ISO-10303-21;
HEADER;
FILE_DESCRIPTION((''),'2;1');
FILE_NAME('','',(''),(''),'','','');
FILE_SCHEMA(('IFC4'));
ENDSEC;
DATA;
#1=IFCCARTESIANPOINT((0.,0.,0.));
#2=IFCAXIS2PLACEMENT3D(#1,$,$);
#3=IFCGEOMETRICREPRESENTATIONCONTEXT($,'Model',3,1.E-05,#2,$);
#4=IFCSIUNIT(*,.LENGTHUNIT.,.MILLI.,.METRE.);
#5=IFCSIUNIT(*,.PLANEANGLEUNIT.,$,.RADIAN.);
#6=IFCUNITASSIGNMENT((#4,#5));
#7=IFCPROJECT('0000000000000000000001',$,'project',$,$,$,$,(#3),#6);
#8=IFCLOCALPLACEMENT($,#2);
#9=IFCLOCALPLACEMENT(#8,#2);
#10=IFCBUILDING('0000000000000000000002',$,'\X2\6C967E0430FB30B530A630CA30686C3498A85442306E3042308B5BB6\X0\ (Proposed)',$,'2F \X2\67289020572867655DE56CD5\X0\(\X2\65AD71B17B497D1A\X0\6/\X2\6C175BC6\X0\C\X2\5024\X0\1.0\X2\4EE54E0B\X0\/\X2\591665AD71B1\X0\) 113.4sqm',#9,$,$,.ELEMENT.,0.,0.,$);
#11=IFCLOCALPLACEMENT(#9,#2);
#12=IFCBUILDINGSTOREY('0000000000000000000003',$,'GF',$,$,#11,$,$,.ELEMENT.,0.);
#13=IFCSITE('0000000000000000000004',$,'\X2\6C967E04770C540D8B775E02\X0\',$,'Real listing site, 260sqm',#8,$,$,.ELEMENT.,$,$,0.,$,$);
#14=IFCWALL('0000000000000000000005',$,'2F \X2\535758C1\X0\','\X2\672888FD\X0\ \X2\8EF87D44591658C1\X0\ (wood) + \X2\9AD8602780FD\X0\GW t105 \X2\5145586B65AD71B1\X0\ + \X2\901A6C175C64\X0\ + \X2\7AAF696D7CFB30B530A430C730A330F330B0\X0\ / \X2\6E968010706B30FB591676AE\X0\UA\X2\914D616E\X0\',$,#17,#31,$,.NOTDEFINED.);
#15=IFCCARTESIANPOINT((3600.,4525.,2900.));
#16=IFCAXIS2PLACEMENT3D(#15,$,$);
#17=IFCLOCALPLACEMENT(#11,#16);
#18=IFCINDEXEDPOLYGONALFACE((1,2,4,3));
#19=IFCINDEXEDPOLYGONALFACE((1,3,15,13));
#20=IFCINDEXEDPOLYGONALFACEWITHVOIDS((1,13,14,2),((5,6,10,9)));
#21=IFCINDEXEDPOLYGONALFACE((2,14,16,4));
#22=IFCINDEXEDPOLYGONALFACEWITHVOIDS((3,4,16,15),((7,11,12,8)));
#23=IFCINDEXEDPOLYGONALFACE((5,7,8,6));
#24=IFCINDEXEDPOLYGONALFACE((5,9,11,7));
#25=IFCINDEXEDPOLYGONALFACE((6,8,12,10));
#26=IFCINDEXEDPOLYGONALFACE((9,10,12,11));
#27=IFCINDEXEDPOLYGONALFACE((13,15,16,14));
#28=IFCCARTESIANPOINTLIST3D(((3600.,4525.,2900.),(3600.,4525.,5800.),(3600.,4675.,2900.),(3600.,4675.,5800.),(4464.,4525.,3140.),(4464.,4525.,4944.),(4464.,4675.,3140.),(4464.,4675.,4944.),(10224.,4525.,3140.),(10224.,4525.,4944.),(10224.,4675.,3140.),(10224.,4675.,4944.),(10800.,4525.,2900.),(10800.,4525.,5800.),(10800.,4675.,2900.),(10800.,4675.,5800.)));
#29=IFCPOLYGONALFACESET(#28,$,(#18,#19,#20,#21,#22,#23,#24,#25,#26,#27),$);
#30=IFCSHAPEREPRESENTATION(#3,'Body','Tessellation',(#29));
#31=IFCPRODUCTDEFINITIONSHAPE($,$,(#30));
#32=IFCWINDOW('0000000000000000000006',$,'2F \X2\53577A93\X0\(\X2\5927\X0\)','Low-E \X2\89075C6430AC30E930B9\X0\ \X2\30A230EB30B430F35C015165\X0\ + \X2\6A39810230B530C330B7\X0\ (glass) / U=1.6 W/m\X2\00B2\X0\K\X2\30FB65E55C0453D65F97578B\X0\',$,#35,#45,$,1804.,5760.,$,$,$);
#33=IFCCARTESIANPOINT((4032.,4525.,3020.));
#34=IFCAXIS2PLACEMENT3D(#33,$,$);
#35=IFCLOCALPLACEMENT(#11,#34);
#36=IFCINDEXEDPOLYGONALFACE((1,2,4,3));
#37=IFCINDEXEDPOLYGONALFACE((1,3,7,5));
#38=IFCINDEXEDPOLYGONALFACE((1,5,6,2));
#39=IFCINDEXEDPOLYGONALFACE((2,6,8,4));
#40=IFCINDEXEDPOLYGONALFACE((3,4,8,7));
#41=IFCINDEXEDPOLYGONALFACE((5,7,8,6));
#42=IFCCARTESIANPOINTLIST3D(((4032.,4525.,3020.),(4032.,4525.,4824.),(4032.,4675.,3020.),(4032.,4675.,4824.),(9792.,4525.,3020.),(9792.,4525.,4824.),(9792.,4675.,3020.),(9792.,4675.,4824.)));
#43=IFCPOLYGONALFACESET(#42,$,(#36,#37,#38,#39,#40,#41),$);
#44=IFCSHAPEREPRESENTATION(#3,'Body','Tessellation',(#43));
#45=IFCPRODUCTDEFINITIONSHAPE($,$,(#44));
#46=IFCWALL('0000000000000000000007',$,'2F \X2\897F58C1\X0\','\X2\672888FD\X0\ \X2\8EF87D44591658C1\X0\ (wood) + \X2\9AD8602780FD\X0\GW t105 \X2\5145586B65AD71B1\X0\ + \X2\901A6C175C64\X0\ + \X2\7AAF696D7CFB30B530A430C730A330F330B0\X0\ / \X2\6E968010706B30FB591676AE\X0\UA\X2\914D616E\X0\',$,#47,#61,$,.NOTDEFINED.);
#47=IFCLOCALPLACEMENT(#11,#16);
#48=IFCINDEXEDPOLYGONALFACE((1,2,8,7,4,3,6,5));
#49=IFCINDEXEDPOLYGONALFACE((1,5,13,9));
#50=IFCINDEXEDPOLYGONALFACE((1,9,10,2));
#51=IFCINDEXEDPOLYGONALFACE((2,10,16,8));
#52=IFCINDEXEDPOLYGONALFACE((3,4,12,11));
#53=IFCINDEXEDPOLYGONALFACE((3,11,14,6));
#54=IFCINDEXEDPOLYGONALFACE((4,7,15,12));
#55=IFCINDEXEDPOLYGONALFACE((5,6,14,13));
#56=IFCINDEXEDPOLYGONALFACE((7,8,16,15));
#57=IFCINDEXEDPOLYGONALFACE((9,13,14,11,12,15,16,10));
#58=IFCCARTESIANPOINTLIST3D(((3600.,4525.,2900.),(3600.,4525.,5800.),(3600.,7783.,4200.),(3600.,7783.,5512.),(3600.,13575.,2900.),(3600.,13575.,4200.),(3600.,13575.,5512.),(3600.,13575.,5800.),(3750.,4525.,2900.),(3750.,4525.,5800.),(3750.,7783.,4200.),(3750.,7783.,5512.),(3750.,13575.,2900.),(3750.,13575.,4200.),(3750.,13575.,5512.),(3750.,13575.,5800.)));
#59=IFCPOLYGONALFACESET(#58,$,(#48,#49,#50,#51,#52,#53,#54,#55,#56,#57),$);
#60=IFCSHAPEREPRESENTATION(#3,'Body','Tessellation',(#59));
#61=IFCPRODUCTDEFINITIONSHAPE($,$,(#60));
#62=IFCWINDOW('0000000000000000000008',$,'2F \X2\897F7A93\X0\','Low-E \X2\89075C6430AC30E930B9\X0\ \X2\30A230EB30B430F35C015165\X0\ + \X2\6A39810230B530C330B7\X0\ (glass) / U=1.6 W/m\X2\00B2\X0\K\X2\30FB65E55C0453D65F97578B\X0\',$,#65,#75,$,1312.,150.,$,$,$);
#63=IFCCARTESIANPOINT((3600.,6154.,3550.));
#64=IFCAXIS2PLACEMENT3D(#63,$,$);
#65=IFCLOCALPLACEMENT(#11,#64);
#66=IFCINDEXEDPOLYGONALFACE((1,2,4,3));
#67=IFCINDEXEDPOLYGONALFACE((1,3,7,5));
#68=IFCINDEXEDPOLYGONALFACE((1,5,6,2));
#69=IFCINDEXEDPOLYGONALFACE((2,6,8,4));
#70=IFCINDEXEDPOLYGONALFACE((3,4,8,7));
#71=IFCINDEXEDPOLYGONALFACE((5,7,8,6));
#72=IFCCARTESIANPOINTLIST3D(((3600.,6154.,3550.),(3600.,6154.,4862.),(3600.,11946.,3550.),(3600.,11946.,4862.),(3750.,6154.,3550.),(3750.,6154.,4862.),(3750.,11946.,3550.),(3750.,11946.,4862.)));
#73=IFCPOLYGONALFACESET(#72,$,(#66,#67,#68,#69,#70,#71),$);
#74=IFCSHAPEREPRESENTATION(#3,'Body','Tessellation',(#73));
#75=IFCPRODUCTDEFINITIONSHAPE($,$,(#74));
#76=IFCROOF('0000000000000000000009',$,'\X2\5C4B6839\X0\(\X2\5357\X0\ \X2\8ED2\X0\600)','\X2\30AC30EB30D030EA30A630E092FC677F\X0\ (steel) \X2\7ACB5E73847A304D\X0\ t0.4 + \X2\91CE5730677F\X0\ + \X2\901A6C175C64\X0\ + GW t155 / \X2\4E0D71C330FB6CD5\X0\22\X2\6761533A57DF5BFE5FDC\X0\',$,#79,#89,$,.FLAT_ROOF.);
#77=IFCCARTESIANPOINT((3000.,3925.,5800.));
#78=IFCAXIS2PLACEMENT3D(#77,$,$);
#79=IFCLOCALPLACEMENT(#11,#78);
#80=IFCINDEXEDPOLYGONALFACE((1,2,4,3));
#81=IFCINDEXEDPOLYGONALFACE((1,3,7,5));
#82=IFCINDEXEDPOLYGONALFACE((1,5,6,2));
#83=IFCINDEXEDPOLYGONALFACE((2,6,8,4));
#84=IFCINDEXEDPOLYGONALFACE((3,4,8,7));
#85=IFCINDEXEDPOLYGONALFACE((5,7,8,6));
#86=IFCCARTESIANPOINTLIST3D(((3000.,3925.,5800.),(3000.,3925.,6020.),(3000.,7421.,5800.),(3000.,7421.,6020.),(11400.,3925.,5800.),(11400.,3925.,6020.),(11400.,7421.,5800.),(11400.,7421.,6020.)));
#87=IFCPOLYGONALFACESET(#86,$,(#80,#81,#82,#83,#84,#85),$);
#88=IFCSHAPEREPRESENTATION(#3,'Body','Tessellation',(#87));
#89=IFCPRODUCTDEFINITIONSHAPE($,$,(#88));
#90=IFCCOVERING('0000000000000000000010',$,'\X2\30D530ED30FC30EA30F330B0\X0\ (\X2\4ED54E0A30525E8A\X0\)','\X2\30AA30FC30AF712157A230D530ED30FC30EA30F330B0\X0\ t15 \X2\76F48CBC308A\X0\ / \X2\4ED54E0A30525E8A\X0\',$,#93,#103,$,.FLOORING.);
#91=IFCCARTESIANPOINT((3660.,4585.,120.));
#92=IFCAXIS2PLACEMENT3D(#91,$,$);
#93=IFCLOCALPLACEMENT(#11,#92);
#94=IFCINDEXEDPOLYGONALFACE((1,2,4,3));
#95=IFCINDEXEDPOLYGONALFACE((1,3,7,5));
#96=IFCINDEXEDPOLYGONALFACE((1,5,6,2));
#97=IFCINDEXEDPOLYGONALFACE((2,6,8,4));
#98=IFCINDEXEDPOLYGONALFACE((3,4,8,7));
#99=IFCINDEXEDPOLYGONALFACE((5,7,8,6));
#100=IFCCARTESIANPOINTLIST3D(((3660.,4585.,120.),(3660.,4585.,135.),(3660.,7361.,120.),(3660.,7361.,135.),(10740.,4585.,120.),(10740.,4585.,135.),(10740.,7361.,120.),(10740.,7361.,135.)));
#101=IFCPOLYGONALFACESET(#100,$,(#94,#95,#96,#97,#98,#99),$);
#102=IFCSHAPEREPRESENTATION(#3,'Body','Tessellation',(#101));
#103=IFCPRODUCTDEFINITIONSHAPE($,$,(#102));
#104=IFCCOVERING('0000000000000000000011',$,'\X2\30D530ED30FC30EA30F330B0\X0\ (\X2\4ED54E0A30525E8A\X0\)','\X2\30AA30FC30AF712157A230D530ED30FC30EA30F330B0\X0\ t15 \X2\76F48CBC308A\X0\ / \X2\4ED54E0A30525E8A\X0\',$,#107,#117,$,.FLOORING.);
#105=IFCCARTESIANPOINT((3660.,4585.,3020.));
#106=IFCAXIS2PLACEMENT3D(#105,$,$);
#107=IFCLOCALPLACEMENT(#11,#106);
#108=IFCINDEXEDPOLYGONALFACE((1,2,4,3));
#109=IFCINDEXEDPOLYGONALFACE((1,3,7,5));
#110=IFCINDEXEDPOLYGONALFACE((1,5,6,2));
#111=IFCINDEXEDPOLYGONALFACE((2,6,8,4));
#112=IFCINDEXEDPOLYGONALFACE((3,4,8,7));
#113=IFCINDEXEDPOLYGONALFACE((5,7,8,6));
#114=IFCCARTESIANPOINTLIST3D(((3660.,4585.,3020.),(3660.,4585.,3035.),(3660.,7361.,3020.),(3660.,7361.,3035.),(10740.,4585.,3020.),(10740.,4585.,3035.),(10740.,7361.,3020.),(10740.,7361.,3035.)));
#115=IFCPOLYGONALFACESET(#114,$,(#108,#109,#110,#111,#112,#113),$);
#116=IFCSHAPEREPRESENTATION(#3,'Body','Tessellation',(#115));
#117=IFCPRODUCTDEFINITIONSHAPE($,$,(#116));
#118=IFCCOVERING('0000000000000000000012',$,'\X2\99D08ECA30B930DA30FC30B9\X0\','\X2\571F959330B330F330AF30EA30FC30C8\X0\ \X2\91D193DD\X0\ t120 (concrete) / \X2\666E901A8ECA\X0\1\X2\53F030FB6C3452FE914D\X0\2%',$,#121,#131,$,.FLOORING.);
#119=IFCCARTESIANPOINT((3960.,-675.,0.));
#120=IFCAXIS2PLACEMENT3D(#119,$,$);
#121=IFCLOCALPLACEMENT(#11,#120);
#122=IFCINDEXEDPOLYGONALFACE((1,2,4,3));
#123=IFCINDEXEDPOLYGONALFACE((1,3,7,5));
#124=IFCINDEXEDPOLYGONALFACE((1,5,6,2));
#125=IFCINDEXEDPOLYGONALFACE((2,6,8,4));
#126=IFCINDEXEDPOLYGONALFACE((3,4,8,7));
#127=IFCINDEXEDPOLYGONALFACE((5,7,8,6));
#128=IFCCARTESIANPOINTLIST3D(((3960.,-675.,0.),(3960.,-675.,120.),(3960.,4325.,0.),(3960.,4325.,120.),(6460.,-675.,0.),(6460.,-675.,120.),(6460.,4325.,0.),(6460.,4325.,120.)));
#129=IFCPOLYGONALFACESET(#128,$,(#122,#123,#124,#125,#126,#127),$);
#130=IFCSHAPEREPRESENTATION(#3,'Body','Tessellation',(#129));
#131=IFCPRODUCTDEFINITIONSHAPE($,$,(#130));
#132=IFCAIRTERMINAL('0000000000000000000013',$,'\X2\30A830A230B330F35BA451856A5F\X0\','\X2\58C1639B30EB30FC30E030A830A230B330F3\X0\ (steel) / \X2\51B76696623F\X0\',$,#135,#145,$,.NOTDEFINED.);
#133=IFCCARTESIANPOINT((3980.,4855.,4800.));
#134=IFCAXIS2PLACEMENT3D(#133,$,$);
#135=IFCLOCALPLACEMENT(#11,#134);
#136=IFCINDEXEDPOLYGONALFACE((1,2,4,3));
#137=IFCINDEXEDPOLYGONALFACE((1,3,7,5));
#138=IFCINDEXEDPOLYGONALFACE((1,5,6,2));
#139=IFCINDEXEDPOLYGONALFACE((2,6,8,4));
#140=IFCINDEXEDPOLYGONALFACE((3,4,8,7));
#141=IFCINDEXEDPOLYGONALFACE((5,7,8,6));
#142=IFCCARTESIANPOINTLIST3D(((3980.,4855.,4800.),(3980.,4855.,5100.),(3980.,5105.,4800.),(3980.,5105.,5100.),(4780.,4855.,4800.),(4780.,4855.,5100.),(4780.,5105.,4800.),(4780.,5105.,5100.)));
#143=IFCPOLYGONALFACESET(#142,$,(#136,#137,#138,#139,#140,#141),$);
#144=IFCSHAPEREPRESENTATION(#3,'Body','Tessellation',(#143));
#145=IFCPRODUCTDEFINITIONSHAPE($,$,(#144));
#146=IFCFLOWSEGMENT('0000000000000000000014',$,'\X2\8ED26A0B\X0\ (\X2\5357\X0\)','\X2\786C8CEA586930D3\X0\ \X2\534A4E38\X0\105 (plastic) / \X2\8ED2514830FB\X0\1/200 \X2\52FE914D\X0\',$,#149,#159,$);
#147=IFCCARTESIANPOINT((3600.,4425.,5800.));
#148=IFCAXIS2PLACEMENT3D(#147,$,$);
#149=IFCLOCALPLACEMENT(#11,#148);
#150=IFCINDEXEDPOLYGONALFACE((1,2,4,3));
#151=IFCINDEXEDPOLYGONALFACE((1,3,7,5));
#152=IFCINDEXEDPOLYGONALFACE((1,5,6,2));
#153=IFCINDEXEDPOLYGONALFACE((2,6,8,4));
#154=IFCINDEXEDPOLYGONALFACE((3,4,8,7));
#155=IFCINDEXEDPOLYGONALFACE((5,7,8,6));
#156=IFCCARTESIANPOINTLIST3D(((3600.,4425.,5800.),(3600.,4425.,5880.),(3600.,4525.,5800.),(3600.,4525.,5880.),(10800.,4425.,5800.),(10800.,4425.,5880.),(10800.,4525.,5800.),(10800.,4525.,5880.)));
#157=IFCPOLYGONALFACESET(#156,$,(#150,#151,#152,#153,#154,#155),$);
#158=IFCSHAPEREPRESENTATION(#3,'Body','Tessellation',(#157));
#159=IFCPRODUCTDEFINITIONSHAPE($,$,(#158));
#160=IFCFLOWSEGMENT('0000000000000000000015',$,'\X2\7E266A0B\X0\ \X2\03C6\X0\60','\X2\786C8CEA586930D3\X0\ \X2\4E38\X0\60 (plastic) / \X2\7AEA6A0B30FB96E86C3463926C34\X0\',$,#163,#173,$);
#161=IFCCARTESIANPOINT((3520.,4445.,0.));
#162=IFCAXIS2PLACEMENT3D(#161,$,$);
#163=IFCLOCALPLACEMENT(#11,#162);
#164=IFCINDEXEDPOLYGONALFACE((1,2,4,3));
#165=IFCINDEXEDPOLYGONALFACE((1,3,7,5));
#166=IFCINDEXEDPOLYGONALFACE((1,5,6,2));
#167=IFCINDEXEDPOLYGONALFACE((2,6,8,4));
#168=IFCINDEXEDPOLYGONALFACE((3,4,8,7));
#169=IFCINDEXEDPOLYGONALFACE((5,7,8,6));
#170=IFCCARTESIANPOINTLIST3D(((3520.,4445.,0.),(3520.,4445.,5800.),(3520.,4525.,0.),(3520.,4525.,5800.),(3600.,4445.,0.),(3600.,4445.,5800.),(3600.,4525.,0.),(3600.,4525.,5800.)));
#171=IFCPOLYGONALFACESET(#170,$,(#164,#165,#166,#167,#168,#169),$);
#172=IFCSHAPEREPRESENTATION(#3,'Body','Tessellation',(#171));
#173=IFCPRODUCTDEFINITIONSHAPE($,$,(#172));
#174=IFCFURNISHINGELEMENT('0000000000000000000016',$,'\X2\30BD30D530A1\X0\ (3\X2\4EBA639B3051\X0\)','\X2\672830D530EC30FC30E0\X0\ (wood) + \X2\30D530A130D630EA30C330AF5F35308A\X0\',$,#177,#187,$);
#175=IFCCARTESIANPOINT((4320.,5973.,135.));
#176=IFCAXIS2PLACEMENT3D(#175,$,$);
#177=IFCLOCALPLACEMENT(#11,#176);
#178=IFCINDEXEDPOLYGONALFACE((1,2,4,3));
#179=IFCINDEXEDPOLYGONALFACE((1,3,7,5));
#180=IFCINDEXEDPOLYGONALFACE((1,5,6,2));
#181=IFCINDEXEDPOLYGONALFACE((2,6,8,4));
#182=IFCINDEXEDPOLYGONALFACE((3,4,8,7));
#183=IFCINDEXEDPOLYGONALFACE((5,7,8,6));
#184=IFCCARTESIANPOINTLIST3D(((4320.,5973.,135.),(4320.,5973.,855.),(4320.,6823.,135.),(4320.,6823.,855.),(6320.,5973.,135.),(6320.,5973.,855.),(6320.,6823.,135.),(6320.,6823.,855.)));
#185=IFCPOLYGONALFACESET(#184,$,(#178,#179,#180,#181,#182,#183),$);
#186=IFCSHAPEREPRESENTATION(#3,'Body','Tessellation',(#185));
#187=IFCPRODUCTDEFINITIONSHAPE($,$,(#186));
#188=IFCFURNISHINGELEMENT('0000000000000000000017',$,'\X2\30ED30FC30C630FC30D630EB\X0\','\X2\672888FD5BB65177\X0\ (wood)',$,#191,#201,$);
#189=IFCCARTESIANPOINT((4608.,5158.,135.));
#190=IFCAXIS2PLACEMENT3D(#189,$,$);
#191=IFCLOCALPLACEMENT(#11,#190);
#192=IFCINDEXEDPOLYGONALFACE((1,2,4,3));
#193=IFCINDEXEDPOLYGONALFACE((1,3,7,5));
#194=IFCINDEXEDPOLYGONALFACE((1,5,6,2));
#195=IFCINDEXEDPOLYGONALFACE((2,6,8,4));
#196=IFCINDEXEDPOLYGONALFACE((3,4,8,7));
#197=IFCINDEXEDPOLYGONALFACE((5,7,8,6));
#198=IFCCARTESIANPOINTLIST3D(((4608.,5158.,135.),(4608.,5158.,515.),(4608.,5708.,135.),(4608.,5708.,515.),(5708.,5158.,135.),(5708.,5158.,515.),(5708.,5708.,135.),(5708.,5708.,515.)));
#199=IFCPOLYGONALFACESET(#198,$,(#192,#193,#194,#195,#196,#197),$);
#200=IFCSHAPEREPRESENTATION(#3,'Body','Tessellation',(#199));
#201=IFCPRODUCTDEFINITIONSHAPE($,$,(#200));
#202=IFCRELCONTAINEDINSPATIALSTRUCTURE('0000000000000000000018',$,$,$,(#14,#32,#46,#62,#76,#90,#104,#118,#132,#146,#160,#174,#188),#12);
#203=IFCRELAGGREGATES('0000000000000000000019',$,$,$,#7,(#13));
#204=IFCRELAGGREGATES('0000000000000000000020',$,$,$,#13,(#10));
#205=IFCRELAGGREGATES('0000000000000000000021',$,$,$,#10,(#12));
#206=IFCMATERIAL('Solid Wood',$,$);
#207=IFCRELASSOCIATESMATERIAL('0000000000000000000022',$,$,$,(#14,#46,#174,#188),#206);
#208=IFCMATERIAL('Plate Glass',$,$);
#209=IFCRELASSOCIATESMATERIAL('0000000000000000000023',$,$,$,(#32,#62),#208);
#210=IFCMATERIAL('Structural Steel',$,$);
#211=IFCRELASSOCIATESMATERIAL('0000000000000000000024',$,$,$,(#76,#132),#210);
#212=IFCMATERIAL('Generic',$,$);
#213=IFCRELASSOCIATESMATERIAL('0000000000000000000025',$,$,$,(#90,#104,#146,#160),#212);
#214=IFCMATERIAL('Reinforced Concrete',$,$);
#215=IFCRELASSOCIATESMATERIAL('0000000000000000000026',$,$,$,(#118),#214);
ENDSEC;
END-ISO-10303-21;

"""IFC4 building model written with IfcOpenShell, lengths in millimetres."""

from ifc_helpers import new_model, si_unit, frame, frame_2d, origin, place, context, project, spatial, rectangle, extrude, material, element, fill, save


model = new_model("IFC4")

# Units and contexts
model_context = context("Model", 3, precision=1e-05, world=origin())
ifc_project = project(units=[si_unit("LENGTHUNIT", "METRE", prefix="MILLI"), si_unit("PLANEANGLEUNIT", "RADIAN")], contexts=[model_context])

# Site, building, storey
site_placement = place(None, origin())
site = spatial("IfcSite", under=ifc_project, at=site_placement, Name="沖縄県名護市", ObjectType="Real listing site, 260sqm", CompositionType="ELEMENT", RefElevation=0.0)
building_placement = place(site_placement, origin())
building = spatial("IfcBuilding", under=site, at=building_placement, Name="沖縄・サウナと水風呂のある家 (Proposed)", ObjectType="2F 木造在来工法(断熱等級6/気密C値1.0以下/外断熱) 113.4sqm", CompositionType="ELEMENT", ElevationOfRefHeight=0.0, ElevationOfTerrain=0.0)
storey_placement = place(building_placement, origin())
storey = spatial("IfcBuildingStorey", under=building, at=storey_placement, Name="GF", CompositionType="ELEMENT", Elevation=0.0)

# Shared definitions
ifc_material_1 = material(Name="Solid Wood")

# Shared definitions
ifc_material_2 = material(Name="Reinforced Concrete")

# Shared definitions
ifc_material_3 = material(Name="Plate Glass")

# Walls, openings, windows
wall_1_placement = place(storey_placement, frame((3600.0, 4525.0, 2900.0)))
wall_1 = element("IfcWall", 1, at=wall_1_placement, inside=storey, material=ifc_material_1, Name="2F 南壁", Description="木製 軸組外壁 (wood) + 高性能GW t105 充填断熱 + 通気層 + 窯業系サイディング / 準耐火・外皮UA配慮", PredefinedType="NOTDEFINED", context=model_context, shape_type="SweptSolid", body=[
    extrude(rectangle(XDim=7200.0, YDim=150.0, at=frame_2d((3600.0, 75.0))), frame((3600.0, 4525.0, 2900.0)), (0.0, 0.0, 1.0), 2900.0),
])
opening_1_placement = place(storey_placement, frame((4032.0, 4525.0, 3020.0)))
opening_1 = element("IfcOpeningElement", 2, at=opening_1_placement, cuts=wall_1, PredefinedType="NOTDEFINED", context=model_context, shape_type="SweptSolid", body=[
    extrude(rectangle(XDim=5760.0, YDim=150.0, at=frame_2d((2880.0, 75.0))), frame((4032.0, 4525.0, 3020.0)), (0.0, 0.0, 1.0), 1804.0),
])
window_1_placement = place(storey_placement, frame((4032.0, 4525.0, 3020.0)))
window_1 = element("IfcWindow", 3, at=window_1_placement, inside=storey, material=ifc_material_3, Name="2F 南窓(大)", Description="Low-E 複層ガラス アルゴン封入 + 樹脂サッシ (glass) / U=1.6 W/m²K・日射取得型", OverallHeight=1804.0, OverallWidth=5760.0, context=model_context, shape_type="SweptSolid", body=[
    extrude(rectangle(XDim=5760.0, YDim=150.0, at=frame_2d((2880.0, 75.0))), frame((4032.0, 4525.0, 3020.0)), (0.0, 0.0, 1.0), 1804.0),
])
fill(opening_1, window_1)
wall_2_placement = place(storey_placement, frame((3600.0, 4525.0, 2900.0)))
wall_2 = element("IfcWall", 4, at=wall_2_placement, inside=storey, material=ifc_material_1, Name="2F 西壁", Description="木製 軸組外壁 (wood) + 高性能GW t105 充填断熱 + 通気層 + 窯業系サイディング / 準耐火・外皮UA配慮", PredefinedType="NOTDEFINED", context=model_context, shape_type="SweptSolid", body=[
    extrude(rectangle(XDim=150.0, YDim=9050.0, at=frame_2d((75.0, 4525.0))), frame((3600.0, 4525.0, 2900.0)), (0.0, 0.0, 1.0), 2900.0),
])
opening_2_placement = place(storey_placement, frame((3600.0, 6154.0, 3550.0)))
opening_2 = element("IfcOpeningElement", 5, at=opening_2_placement, cuts=wall_2, PredefinedType="NOTDEFINED", context=model_context, shape_type="SweptSolid", body=[
    extrude(rectangle(XDim=150.0, YDim=5792.0, at=frame_2d((75.0, 2896.0))), frame((3600.0, 6154.0, 3550.0)), (0.0, 0.0, 1.0), 1312.0),
])
window_2_placement = place(storey_placement, frame((3600.0, 6154.0, 3550.0)))
window_2 = element("IfcWindow", 6, at=window_2_placement, inside=storey, material=ifc_material_3, Name="2F 西窓", Description="Low-E 複層ガラス アルゴン封入 + 樹脂サッシ (glass) / U=1.6 W/m²K・日射取得型", OverallHeight=1312.0, OverallWidth=150.0, context=model_context, shape_type="SweptSolid", body=[
    extrude(rectangle(XDim=150.0, YDim=5792.0, at=frame_2d((75.0, 2896.0))), frame((3600.0, 6154.0, 3550.0)), (0.0, 0.0, 1.0), 1312.0),
])
fill(opening_2, window_2)

# Roof
ifc_material_4 = material(Name="Structural Steel")
for number, where, name in (
    (7, (3000.0, 3925.0, 5800.0), "屋根(南 軒600)"),
):
    element("IfcRoof", number, at=place(storey_placement, frame(where)), inside=storey, material=ifc_material_4, Name=name, Description="ガルバリウム鋼板 (steel) 立平葺き t0.4 + 野地板 + 通気層 + GW t155 / 不燃・法22条区域対応", PredefinedType="FLAT_ROOF", context=model_context, shape_type="SweptSolid", body=[
        extrude(rectangle(XDim=8400.0, YDim=3496.0, at=frame_2d((4200.0, 1748.0))), frame((3000.0, 3925.0, 5800.0)), (0.0, 0.0, 1.0), 220.0),
    ])

# Coverings
ifc_material_5 = material(Name="Generic")
covering_1_placement = place(storey_placement, frame((3660.0, 4585.0, 120.0)))
element("IfcCovering", 8, at=covering_1_placement, inside=storey, material=ifc_material_5, Name="フローリング (仕上げ床)", Description="オーク無垢フローリング t15 直貼り / 仕上げ床", PredefinedType="FLOORING", context=model_context, shape_type="SweptSolid", body=[
    extrude(rectangle(XDim=7080.0, YDim=2776.0, at=frame_2d((3540.0, 1388.0))), frame((3660.0, 4585.0, 120.0)), (0.0, 0.0, 1.0), 15.0),
])
covering_2_placement = place(storey_placement, frame((3660.0, 4585.0, 3020.0)))
element("IfcCovering", 9, at=covering_2_placement, inside=storey, material=ifc_material_5, Name="フローリング (仕上げ床)", Description="オーク無垢フローリング t15 直貼り / 仕上げ床", PredefinedType="FLOORING", context=model_context, shape_type="SweptSolid", body=[
    extrude(rectangle(XDim=7080.0, YDim=2776.0, at=frame_2d((3540.0, 1388.0))), frame((3660.0, 4585.0, 3020.0)), (0.0, 0.0, 1.0), 15.0),
])
covering_3_placement = place(storey_placement, frame((3960.0, -675.0, 0.0)))
element("IfcCovering", 10, at=covering_3_placement, inside=storey, material=ifc_material_2, Name="駐車スペース", Description="土間コンクリート 金鏝 t120 (concrete) / 普通車1台・水勾配2%", PredefinedType="FLOORING", context=model_context, shape_type="SweptSolid", body=[
    extrude(rectangle(XDim=2500.0, YDim=5000.0, at=frame_2d((1250.0, 2500.0))), frame((3960.0, -675.0, 0.0)), (0.0, 0.0, 1.0), 120.0),
])

# Air terminal
air_terminal_placement = place(storey_placement, frame((3980.0, 4855.0, 4800.0)))
element("IfcAirTerminal", 11, at=air_terminal_placement, inside=storey, material=ifc_material_4, Name="エアコン室内機", Description="壁掛ルームエアコン (steel) / 冷暖房", PredefinedType="NOTDEFINED", context=model_context, shape_type="SweptSolid", body=[
    extrude(rectangle(XDim=800.0, YDim=250.0, at=frame_2d((400.0, 125.0))), frame((3980.0, 4855.0, 4800.0)), (0.0, 0.0, 1.0), 300.0),
])

# Flow segments
flow_segment_1_placement = place(storey_placement, frame((3600.0, 4425.0, 5800.0)))
element("IfcFlowSegment", 12, at=flow_segment_1_placement, inside=storey, material=ifc_material_5, Name="軒樋 (南)", Description="硬質塩ビ 半丸105 (plastic) / 軒先・1/200 勾配", context=model_context, shape_type="SweptSolid", body=[
    extrude(rectangle(XDim=7200.0, YDim=100.0, at=frame_2d((3600.0, 50.0))), frame((3600.0, 4425.0, 5800.0)), (0.0, 0.0, 1.0), 80.0),
])
flow_segment_2_placement = place(storey_placement, frame((3520.0, 4445.0, 0.0)))
element("IfcFlowSegment", 13, at=flow_segment_2_placement, inside=storey, material=ifc_material_5, Name="縦樋 φ60", Description="硬質塩ビ 丸60 (plastic) / 竪樋・雨水排水", context=model_context, shape_type="SweptSolid", body=[
    extrude(rectangle(XDim=80.0, YDim=80.0, at=frame_2d((40.0, 40.0))), frame((3520.0, 4445.0, 0.0)), (0.0, 0.0, 1.0), 5800.0),
])

# Furnishing elements
furnishing_1_placement = place(storey_placement, frame((4320.0, 5973.0, 135.0)))
element("IfcFurnishingElement", 14, at=furnishing_1_placement, inside=storey, material=ifc_material_1, Name="ソファ (3人掛け)", Description="木フレーム (wood) + ファブリック張り", context=model_context, shape_type="SweptSolid", body=[
    extrude(rectangle(XDim=2000.0, YDim=850.0, at=frame_2d((1000.0, 425.0))), frame((4320.0, 5973.0, 135.0)), (0.0, 0.0, 1.0), 720.0),
])
furnishing_2_placement = place(storey_placement, frame((4608.0, 5158.0, 135.0)))
element("IfcFurnishingElement", 15, at=furnishing_2_placement, inside=storey, material=ifc_material_1, Name="ローテーブル", Description="木製家具 (wood)", context=model_context, shape_type="SweptSolid", body=[
    extrude(rectangle(XDim=1100.0, YDim=550.0, at=frame_2d((550.0, 275.0))), frame((4608.0, 5158.0, 135.0)), (0.0, 0.0, 1.0), 380.0),
])

save(model, "model.ifc")
